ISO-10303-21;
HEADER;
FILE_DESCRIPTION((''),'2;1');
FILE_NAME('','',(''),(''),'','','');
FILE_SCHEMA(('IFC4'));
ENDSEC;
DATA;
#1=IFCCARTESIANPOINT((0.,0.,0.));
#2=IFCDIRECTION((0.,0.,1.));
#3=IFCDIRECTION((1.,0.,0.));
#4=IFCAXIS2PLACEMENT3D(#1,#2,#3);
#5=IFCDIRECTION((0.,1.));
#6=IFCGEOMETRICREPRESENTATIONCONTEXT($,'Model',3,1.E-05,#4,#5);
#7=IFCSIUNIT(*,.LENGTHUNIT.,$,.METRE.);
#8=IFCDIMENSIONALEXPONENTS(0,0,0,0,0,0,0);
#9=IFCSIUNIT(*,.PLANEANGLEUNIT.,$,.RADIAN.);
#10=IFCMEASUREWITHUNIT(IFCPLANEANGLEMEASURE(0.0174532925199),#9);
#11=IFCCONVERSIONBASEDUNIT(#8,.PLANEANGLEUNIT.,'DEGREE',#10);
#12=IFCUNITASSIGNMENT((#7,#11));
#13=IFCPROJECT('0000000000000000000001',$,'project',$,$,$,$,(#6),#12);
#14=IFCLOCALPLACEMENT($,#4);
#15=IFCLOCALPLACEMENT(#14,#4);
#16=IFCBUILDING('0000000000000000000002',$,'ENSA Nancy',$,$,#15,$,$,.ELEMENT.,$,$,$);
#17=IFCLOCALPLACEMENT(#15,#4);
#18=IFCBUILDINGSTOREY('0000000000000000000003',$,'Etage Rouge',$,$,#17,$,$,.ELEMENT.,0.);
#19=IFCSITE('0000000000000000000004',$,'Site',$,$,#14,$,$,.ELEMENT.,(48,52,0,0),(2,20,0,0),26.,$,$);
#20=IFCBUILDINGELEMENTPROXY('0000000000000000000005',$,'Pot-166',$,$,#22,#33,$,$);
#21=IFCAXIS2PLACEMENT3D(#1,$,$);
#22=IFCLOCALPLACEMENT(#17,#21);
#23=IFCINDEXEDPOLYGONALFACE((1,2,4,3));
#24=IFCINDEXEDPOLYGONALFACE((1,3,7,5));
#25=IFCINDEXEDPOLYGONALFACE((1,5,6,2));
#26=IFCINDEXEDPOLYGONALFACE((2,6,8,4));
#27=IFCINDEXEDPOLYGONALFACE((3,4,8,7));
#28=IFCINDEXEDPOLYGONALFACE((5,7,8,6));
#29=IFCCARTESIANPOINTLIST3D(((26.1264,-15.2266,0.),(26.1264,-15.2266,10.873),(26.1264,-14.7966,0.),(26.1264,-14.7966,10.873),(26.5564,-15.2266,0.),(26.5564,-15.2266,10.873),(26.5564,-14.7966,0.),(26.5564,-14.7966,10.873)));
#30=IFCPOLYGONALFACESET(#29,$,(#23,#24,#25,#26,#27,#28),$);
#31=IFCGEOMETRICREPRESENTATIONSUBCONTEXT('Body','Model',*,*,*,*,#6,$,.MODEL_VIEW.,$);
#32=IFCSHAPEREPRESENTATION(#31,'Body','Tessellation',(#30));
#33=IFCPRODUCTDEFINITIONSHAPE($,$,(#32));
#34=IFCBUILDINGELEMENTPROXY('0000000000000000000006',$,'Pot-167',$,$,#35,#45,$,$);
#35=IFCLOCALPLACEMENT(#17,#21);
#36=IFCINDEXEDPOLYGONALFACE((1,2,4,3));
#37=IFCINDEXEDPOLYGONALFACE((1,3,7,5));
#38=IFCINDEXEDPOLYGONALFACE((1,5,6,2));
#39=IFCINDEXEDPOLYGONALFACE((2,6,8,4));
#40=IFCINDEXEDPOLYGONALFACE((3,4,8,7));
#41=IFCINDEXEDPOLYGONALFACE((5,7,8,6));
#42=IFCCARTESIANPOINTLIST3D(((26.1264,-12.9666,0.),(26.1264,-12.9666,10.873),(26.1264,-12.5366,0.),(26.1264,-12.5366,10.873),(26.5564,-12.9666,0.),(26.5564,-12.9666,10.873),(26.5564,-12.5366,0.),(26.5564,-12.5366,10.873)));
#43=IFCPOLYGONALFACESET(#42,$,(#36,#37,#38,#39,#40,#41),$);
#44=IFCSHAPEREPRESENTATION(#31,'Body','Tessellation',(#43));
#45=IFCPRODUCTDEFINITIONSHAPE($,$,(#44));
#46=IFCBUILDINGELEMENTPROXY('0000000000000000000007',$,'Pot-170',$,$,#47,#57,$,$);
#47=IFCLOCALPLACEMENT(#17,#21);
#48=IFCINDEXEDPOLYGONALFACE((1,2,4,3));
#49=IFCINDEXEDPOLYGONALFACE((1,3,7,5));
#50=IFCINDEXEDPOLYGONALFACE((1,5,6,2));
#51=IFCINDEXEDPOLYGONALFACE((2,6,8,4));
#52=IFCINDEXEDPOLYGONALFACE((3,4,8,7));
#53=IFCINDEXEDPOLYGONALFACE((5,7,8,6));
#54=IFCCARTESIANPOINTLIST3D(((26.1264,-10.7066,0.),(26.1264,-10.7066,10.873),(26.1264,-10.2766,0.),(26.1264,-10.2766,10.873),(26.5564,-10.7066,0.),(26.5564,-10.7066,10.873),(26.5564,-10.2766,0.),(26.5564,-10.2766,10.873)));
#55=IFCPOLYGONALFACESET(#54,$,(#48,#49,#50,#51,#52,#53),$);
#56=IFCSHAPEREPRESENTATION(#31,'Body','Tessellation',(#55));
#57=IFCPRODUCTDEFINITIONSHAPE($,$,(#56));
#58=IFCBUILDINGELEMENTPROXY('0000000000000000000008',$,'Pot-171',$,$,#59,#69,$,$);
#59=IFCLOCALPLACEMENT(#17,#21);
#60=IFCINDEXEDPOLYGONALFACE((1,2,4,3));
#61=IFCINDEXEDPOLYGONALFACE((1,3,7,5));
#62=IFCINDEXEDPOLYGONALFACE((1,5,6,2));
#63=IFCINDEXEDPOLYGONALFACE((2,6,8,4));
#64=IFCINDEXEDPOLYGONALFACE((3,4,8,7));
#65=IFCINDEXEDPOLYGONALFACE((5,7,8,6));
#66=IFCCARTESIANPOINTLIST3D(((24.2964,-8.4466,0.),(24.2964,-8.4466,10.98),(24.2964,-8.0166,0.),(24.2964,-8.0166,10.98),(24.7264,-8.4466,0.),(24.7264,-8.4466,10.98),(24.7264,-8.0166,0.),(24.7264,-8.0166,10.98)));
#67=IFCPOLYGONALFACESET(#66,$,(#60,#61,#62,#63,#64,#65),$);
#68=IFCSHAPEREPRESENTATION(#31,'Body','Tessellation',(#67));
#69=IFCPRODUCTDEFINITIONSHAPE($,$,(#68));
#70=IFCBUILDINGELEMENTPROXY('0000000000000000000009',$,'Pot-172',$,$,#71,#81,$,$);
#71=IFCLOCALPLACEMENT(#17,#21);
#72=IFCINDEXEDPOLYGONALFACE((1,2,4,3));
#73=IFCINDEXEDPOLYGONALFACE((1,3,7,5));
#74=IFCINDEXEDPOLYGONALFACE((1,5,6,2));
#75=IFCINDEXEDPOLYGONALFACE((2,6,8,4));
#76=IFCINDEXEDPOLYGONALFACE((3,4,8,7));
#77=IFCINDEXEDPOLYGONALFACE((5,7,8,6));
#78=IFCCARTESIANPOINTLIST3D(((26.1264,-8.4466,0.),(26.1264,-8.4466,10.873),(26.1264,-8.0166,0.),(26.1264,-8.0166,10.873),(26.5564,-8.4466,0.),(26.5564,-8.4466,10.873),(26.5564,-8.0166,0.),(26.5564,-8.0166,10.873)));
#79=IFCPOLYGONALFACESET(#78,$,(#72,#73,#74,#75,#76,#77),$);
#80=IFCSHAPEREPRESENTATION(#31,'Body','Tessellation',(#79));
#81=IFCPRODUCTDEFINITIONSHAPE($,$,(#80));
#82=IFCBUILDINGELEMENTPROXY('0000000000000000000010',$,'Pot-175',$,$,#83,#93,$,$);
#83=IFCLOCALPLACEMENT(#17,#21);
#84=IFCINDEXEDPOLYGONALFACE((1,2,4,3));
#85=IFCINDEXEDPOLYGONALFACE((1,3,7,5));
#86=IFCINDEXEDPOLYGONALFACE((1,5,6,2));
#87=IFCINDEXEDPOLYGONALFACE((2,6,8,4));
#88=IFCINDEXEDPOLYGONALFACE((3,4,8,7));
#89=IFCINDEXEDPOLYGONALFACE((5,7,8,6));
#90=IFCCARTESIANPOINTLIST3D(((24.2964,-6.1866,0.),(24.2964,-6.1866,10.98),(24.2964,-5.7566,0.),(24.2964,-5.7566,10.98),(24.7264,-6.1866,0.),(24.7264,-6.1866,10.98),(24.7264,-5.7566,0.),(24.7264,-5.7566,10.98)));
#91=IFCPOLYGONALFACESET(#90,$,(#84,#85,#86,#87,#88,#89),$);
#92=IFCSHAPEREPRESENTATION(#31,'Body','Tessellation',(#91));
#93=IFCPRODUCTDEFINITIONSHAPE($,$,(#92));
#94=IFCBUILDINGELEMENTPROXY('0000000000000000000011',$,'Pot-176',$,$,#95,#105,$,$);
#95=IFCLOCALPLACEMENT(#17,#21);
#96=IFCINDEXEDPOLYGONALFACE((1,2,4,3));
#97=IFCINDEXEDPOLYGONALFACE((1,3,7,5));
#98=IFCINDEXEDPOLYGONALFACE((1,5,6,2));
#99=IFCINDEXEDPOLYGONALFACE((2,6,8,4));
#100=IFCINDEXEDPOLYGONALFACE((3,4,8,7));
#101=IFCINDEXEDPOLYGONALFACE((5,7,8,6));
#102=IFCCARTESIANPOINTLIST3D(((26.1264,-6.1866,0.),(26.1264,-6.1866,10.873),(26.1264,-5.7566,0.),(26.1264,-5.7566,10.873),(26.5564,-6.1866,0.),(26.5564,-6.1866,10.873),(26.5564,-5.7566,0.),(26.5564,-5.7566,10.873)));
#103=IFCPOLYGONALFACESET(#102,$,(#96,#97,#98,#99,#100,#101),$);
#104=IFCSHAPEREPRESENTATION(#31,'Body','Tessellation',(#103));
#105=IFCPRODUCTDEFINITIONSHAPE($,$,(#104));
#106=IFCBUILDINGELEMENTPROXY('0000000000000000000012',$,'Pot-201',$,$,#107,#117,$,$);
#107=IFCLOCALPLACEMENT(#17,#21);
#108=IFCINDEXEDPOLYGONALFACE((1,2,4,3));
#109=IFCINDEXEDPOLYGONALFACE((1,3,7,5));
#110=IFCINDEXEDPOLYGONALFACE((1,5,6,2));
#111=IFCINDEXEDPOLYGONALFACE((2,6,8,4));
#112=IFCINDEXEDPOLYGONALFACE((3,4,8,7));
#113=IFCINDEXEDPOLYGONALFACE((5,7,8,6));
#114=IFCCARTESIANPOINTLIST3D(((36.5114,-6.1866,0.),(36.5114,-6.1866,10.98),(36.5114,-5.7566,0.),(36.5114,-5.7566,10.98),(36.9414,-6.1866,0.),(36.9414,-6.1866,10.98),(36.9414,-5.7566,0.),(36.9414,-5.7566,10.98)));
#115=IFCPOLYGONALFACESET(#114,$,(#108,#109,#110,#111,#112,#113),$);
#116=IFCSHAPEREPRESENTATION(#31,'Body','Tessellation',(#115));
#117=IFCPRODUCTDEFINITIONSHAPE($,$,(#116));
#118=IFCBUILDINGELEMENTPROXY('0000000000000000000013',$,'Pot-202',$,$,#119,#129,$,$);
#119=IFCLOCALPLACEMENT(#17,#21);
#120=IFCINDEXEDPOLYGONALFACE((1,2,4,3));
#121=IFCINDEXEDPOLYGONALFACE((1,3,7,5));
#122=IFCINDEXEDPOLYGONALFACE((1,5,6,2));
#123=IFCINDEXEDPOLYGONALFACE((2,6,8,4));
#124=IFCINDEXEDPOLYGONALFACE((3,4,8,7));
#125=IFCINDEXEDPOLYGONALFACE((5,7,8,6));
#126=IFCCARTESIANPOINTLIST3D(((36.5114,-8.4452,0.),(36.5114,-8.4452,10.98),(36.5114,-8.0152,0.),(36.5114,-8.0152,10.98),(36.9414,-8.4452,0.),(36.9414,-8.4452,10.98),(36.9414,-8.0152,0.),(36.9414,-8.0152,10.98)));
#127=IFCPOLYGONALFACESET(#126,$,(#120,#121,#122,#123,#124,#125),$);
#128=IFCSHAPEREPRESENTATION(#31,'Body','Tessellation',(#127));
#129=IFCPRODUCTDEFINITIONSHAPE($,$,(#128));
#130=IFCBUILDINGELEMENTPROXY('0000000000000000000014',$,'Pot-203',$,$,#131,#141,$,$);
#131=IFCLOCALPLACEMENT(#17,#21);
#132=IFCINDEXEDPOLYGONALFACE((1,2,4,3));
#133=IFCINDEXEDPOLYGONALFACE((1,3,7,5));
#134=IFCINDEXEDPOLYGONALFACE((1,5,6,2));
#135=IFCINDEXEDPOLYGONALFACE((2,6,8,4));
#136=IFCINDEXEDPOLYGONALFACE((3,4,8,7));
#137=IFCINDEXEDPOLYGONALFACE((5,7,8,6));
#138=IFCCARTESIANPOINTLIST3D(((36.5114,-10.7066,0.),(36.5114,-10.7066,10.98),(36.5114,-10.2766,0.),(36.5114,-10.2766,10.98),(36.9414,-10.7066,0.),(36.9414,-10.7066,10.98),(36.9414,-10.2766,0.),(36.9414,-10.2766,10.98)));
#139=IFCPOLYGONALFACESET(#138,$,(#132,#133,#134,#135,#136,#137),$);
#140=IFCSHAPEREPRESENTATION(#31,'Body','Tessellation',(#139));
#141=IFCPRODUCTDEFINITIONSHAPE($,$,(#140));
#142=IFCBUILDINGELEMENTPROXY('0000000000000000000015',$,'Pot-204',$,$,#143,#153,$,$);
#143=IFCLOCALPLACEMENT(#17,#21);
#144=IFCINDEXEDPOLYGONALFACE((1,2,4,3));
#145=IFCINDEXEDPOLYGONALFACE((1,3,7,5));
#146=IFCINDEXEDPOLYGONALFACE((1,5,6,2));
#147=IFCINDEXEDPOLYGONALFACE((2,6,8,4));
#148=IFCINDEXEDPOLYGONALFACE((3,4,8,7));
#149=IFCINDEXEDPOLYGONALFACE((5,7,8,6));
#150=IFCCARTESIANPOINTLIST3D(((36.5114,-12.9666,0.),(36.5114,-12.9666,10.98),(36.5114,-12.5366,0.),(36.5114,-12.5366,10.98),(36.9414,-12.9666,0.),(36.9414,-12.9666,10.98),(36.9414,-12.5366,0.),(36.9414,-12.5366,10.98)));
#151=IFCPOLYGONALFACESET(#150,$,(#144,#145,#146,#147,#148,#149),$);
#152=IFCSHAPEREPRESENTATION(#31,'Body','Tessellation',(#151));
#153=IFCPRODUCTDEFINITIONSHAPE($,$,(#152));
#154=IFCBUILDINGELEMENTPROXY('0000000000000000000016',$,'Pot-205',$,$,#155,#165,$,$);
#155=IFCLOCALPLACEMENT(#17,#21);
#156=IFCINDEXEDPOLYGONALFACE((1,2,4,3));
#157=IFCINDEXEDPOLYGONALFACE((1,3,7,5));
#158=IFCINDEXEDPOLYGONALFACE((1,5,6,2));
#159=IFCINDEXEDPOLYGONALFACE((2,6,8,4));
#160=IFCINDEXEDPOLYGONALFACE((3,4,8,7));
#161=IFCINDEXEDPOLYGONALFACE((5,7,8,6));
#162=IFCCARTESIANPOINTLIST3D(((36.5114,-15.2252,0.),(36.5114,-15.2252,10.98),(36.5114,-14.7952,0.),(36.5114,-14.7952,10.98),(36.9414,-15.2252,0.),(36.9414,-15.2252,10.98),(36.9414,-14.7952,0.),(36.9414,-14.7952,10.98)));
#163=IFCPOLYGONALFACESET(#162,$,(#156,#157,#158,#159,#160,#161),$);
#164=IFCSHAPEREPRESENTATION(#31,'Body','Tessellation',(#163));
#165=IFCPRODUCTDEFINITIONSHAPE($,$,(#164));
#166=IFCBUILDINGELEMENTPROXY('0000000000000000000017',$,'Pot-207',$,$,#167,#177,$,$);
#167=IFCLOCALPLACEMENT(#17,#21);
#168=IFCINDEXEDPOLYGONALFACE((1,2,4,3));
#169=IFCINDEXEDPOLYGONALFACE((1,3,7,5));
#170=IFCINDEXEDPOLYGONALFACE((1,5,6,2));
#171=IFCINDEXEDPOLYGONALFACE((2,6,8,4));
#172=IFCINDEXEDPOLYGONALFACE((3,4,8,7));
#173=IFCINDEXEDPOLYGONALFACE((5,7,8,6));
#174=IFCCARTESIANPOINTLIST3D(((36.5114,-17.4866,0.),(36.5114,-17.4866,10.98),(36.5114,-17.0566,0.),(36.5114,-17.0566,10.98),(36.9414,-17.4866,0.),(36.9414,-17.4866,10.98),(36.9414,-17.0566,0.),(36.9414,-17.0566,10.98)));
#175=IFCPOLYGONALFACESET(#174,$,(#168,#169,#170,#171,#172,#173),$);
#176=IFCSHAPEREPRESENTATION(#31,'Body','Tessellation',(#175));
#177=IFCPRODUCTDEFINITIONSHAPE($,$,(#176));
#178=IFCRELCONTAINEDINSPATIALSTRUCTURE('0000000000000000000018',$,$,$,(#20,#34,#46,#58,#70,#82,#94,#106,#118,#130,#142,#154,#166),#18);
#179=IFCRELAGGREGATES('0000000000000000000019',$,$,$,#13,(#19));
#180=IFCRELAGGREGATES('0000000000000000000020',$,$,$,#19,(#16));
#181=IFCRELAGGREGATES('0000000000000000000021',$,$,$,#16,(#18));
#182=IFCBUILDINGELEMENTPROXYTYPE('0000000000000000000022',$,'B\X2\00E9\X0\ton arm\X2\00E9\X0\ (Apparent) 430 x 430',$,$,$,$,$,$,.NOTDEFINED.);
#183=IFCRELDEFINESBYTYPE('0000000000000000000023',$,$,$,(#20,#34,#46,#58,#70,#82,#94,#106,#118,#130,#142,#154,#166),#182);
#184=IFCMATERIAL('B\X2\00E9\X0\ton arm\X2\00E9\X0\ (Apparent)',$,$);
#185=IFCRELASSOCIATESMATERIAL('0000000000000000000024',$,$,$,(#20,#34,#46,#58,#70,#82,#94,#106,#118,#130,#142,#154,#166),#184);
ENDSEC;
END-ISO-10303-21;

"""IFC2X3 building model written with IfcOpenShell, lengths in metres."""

from ifc_helpers import new_model, entity, si_unit, converted_unit, direction, frame, origin_with_axes, origin_2d_with_axis, place, context, subcontext, project, spatial, rectangle, extrude, material, type_object, element, save


model = new_model("IFC2X3")

# Units and contexts
model_context = context("Model", 3, precision=1e-05, world=origin_with_axes(), true_north=direction((0.0, 1.0)))
body_context = subcontext(model_context, "Body", "Model", "MODEL_VIEW")
ifc_project = project(units=[si_unit("LENGTHUNIT", "METRE"), converted_unit("PLANEANGLEUNIT", "DEGREE", entity("IfcPlaneAngleMeasure", 0.0174532925199), si_unit("PLANEANGLEUNIT", "RADIAN"), dimensions=[0, 0, 0, 0, 0, 0, 0])], contexts=[model_context])

# Site, building, storey
site_placement = place(None, origin_with_axes())
site = spatial("IfcSite", under=ifc_project, at=site_placement, Name="Site", CompositionType="ELEMENT", RefLatitude=(48, 52, 0, 0), RefLongitude=(2, 20, 0, 0), RefElevation=26.0)
building_placement = place(site_placement, origin_with_axes())
building = spatial("IfcBuilding", under=site, at=building_placement, Name="ENSA Nancy", CompositionType="ELEMENT")
storey_placement = place(building_placement, origin_with_axes())
storey = spatial("IfcBuildingStorey", under=building, at=storey_placement, Name="Etage Rouge", CompositionType="ELEMENT", Elevation=0.0)

# Building element proxies
ifc_material_1 = material(Name="Béton armé (Apparent)")
building_element_proxy_type_1 = type_object("IfcBuildingElementProxyType", Name="Béton armé (Apparent) 430 x 430", PredefinedType="NOTDEFINED")
for number, where, z_axis, x_axis, name in (
    (1, (26.3414, -15.0116, 0.0), (0.0, 0.0, 1.0), (1.0, 0.0, 0.0), "Pot-166"),
    (2, (26.3414, -12.7516, 0.0), (0.0, 0.0, 1.0), (1.0, 0.0, 0.0), "Pot-167"),
    (3, (26.3414, -10.4916, 0.0), (0.0, 0.0, 1.0), (1.0, 0.0, 0.0), "Pot-170"),
):
    element("IfcBuildingElementProxy", number, at=place(storey_placement, frame(where, z_axis=z_axis, x_axis=x_axis)), inside=storey, type_object=building_element_proxy_type_1, material=ifc_material_1, Name=name, context=body_context, shape_type="SweptSolid", body=[
        extrude(rectangle(XDim=0.43, YDim=0.43, at=origin_2d_with_axis()), origin_with_axes(), (0.0, 0.0, 1.0), 10.873),
    ])
proxy_1_placement = place(storey_placement, frame((24.5114, -8.2316, 0.0), z_axis=(0.0, 0.0, 1.0), x_axis=(1.0, 0.0, 0.0)))
element("IfcBuildingElementProxy", 4, at=proxy_1_placement, inside=storey, type_object=building_element_proxy_type_1, material=ifc_material_1, Name="Pot-171", context=body_context, shape_type="SweptSolid", body=[
    extrude(rectangle(XDim=0.43, YDim=0.43, at=origin_2d_with_axis()), origin_with_axes(), (0.0, 0.0, 1.0), 10.98),
])
proxy_2_placement = place(storey_placement, frame((26.3414, -8.2316, 0.0), z_axis=(0.0, 0.0, 1.0), x_axis=(1.0, 0.0, 0.0)))
element("IfcBuildingElementProxy", 5, at=proxy_2_placement, inside=storey, type_object=building_element_proxy_type_1, material=ifc_material_1, Name="Pot-172", context=body_context, shape_type="SweptSolid", body=[
    extrude(rectangle(XDim=0.43, YDim=0.43, at=origin_2d_with_axis()), origin_with_axes(), (0.0, 0.0, 1.0), 10.873),
])
proxy_3_placement = place(storey_placement, frame((24.5114, -5.9716, 0.0), z_axis=(0.0, 0.0, 1.0), x_axis=(1.0, 0.0, 0.0)))
element("IfcBuildingElementProxy", 6, at=proxy_3_placement, inside=storey, type_object=building_element_proxy_type_1, material=ifc_material_1, Name="Pot-175", context=body_context, shape_type="SweptSolid", body=[
    extrude(rectangle(XDim=0.43, YDim=0.43, at=origin_2d_with_axis()), origin_with_axes(), (0.0, 0.0, 1.0), 10.98),
])
proxy_4_placement = place(storey_placement, frame((26.3414, -5.9716, 0.0), z_axis=(0.0, 0.0, 1.0), x_axis=(1.0, 0.0, 0.0)))
element("IfcBuildingElementProxy", 7, at=proxy_4_placement, inside=storey, type_object=building_element_proxy_type_1, material=ifc_material_1, Name="Pot-176", context=body_context, shape_type="SweptSolid", body=[
    extrude(rectangle(XDim=0.43, YDim=0.43, at=origin_2d_with_axis()), origin_with_axes(), (0.0, 0.0, 1.0), 10.873),
])
for number, where, z_axis, x_axis, name in (
    (8, (36.7264, -5.9716, 0.0), (0.0, 0.0, 1.0), (1.0, 0.0, 0.0), "Pot-201"),
    (9, (36.7264, -8.2302, 0.0), (0.0, 0.0, 1.0), (1.0, 0.0, 0.0), "Pot-202"),
    (10, (36.7264, -10.4916, 0.0), (0.0, 0.0, 1.0), (1.0, 0.0, 0.0), "Pot-203"),
    (11, (36.7264, -12.7516, 0.0), (0.0, 0.0, 1.0), (1.0, 0.0, 0.0), "Pot-204"),
    (12, (36.7264, -15.0102, 0.0), (0.0, 0.0, 1.0), (1.0, 0.0, 0.0), "Pot-205"),
    (13, (36.7264, -17.2716, 0.0), (0.0, 0.0, 1.0), (1.0, 0.0, 0.0), "Pot-207"),
):
    element("IfcBuildingElementProxy", number, at=place(storey_placement, frame(where, z_axis=z_axis, x_axis=x_axis)), inside=storey, type_object=building_element_proxy_type_1, material=ifc_material_1, Name=name, context=body_context, shape_type="SweptSolid", body=[
        extrude(rectangle(XDim=0.43, YDim=0.43, at=origin_2d_with_axis()), origin_with_axes(), (0.0, 0.0, 1.0), 10.98),
    ])

save(model, "model.ifc")
